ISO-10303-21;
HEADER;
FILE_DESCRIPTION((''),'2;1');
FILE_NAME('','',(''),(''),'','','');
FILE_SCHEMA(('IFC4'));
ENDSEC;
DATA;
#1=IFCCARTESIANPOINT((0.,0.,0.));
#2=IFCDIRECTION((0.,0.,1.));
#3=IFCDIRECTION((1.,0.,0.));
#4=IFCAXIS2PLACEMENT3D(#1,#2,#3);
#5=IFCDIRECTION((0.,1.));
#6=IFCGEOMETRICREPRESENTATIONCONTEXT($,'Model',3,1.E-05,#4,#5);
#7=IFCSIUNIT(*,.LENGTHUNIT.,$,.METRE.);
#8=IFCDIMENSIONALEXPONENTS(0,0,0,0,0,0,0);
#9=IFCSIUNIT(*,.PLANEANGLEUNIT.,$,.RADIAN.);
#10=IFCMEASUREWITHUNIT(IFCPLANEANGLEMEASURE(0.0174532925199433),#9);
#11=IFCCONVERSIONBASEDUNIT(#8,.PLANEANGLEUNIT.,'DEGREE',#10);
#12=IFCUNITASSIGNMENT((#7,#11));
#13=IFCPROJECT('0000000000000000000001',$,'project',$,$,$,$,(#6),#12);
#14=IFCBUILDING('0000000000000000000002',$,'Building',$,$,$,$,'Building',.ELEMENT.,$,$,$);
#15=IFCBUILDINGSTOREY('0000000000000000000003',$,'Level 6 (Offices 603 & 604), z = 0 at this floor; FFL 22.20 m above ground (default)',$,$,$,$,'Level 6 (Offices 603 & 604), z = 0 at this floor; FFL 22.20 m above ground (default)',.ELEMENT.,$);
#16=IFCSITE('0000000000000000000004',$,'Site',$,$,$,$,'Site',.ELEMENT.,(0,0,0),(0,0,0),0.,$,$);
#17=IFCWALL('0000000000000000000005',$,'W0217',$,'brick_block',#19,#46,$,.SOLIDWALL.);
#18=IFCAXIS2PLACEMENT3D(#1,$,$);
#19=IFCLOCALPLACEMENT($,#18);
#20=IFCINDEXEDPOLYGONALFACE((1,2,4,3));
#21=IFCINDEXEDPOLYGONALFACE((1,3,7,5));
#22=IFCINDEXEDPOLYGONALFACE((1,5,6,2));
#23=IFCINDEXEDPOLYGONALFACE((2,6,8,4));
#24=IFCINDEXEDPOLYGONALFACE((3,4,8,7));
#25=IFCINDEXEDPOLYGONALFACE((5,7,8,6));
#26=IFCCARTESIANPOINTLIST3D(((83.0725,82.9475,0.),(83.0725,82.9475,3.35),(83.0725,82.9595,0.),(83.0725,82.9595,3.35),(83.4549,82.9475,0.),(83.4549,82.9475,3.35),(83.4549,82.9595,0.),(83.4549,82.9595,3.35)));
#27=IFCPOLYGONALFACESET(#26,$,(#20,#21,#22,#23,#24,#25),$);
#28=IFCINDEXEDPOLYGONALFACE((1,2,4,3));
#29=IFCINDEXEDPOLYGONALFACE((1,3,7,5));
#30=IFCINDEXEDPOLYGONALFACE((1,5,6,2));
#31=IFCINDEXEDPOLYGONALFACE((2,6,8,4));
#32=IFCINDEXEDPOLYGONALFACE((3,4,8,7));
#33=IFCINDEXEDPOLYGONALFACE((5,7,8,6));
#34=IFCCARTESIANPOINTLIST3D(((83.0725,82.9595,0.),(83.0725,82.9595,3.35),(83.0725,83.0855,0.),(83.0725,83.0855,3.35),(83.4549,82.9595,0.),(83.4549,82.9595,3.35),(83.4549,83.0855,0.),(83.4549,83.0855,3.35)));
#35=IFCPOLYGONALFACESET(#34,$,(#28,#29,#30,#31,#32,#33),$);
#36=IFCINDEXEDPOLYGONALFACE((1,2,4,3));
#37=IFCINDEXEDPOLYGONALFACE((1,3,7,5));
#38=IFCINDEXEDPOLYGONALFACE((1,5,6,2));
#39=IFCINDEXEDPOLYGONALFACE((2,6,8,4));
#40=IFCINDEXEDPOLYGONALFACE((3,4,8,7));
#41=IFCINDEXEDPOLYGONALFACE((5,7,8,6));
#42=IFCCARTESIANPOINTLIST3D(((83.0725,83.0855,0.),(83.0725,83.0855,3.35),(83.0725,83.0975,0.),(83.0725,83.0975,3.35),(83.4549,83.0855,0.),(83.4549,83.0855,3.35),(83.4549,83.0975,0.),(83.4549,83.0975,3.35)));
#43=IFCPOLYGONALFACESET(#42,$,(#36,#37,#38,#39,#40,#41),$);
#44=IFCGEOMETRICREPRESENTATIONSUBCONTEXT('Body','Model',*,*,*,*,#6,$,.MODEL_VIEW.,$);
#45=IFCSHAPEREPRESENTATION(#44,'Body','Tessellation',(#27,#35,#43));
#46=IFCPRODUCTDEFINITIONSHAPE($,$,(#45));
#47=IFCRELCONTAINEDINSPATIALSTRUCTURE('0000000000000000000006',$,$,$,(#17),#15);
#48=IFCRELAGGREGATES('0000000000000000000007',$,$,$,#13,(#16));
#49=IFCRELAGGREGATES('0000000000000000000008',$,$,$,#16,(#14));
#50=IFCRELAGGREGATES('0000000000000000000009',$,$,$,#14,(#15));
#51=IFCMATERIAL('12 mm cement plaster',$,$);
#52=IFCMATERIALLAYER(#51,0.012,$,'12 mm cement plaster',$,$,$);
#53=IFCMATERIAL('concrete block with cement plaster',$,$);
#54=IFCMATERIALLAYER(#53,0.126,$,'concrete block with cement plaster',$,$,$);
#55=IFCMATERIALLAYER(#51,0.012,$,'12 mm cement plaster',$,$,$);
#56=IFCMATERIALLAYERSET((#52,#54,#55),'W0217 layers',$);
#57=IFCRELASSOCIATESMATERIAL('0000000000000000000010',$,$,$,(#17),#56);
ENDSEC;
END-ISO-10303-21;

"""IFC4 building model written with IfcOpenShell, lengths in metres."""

from ifc_helpers import new_model, entity, si_unit, converted_unit, direction, frame, frame_2d, origin_with_axes, origin_2d_with_axis, place, context, subcontext, project, spatial, rectangle, extrude, material, layer, layer_set, layer_usage, element, save


model = new_model("IFC4")

# Units and contexts
model_context = context("Model", 3, precision=1e-05, world=origin_with_axes(), true_north=direction((0.0, 1.0)))
body_context = subcontext(model_context, "Body", "Model", "MODEL_VIEW")
ifc_project = project(units=[si_unit("LENGTHUNIT", "METRE"), converted_unit("PLANEANGLEUNIT", "DEGREE", entity("IfcPlaneAngleMeasure", 0.0174532925199433), si_unit("PLANEANGLEUNIT", "RADIAN"), dimensions=[0, 0, 0, 0, 0, 0, 0])], contexts=[model_context])

# Site, building, storey
site = spatial("IfcSite", under=ifc_project, Name="Site", LongName="Site", CompositionType="ELEMENT", RefLatitude=(0, 0, 0), RefLongitude=(0, 0, 0), RefElevation=0.0)
building = spatial("IfcBuilding", under=site, Name="Building", LongName="Building", CompositionType="ELEMENT")
storey = spatial("IfcBuildingStorey", under=building, Name="Level 6 (Offices 603 & 604), z = 0 at this floor; FFL 22.20 m above ground (default)", LongName="Level 6 (Offices 603 & 604), z = 0 at this floor; FFL 22.20 m above ground (default)", CompositionType="ELEMENT")

# Shared definitions
ifc_material_1 = material(Name="12 mm cement plaster")
ifc_material_2 = material(Name="concrete block with cement plaster")
placement = place(None, origin_with_axes())

# Wall
ifc_layer_1 = layer(ifc_material_1, 0.012, Name="12 mm cement plaster")
ifc_layer_2 = layer(ifc_material_2, 0.126, Name="concrete block with cement plaster")
ifc_layer_3 = layer(ifc_material_1, 0.012, Name="12 mm cement plaster")
ifc_layer_set_1 = layer_set([ifc_layer_1, ifc_layer_2, ifc_layer_3], Name="W0217 layers")
ifc_layer_usage_1 = layer_usage(ifc_layer_set_1, "AXIS2", "POSITIVE", -0.075)
element("IfcWall", 1, at=placement, inside=storey, material=ifc_layer_usage_1, Name="W0217", ObjectType="brick_block", PredefinedType="SOLIDWALL", context=body_context, shape_type="SweptSolid", body=[
    extrude(rectangle(XDim=0.3824, YDim=0.012, at=origin_2d_with_axis()), frame((83.2637, 82.9535, 0.0), z_axis=(0.0, 0.0, 1.0), x_axis=(1.0, 0.0, 0.0)), (0.0, 0.0, 1.0), 3.35),
    extrude(rectangle(XDim=0.3824, YDim=0.126, at=frame_2d((0.0, 0.069), x_axis=(1.0, 0.0))), frame((83.2637, 82.9535, 0.0), z_axis=(0.0, 0.0, 1.0), x_axis=(1.0, 0.0, 0.0)), (0.0, 0.0, 1.0), 3.35),
    extrude(rectangle(XDim=0.3824, YDim=0.012, at=frame_2d((0.0, 0.138), x_axis=(1.0, 0.0))), frame((83.2637, 82.9535, 0.0), z_axis=(0.0, 0.0, 1.0), x_axis=(1.0, 0.0, 0.0)), (0.0, 0.0, 1.0), 3.35),
])

save(model, "model.ifc")
